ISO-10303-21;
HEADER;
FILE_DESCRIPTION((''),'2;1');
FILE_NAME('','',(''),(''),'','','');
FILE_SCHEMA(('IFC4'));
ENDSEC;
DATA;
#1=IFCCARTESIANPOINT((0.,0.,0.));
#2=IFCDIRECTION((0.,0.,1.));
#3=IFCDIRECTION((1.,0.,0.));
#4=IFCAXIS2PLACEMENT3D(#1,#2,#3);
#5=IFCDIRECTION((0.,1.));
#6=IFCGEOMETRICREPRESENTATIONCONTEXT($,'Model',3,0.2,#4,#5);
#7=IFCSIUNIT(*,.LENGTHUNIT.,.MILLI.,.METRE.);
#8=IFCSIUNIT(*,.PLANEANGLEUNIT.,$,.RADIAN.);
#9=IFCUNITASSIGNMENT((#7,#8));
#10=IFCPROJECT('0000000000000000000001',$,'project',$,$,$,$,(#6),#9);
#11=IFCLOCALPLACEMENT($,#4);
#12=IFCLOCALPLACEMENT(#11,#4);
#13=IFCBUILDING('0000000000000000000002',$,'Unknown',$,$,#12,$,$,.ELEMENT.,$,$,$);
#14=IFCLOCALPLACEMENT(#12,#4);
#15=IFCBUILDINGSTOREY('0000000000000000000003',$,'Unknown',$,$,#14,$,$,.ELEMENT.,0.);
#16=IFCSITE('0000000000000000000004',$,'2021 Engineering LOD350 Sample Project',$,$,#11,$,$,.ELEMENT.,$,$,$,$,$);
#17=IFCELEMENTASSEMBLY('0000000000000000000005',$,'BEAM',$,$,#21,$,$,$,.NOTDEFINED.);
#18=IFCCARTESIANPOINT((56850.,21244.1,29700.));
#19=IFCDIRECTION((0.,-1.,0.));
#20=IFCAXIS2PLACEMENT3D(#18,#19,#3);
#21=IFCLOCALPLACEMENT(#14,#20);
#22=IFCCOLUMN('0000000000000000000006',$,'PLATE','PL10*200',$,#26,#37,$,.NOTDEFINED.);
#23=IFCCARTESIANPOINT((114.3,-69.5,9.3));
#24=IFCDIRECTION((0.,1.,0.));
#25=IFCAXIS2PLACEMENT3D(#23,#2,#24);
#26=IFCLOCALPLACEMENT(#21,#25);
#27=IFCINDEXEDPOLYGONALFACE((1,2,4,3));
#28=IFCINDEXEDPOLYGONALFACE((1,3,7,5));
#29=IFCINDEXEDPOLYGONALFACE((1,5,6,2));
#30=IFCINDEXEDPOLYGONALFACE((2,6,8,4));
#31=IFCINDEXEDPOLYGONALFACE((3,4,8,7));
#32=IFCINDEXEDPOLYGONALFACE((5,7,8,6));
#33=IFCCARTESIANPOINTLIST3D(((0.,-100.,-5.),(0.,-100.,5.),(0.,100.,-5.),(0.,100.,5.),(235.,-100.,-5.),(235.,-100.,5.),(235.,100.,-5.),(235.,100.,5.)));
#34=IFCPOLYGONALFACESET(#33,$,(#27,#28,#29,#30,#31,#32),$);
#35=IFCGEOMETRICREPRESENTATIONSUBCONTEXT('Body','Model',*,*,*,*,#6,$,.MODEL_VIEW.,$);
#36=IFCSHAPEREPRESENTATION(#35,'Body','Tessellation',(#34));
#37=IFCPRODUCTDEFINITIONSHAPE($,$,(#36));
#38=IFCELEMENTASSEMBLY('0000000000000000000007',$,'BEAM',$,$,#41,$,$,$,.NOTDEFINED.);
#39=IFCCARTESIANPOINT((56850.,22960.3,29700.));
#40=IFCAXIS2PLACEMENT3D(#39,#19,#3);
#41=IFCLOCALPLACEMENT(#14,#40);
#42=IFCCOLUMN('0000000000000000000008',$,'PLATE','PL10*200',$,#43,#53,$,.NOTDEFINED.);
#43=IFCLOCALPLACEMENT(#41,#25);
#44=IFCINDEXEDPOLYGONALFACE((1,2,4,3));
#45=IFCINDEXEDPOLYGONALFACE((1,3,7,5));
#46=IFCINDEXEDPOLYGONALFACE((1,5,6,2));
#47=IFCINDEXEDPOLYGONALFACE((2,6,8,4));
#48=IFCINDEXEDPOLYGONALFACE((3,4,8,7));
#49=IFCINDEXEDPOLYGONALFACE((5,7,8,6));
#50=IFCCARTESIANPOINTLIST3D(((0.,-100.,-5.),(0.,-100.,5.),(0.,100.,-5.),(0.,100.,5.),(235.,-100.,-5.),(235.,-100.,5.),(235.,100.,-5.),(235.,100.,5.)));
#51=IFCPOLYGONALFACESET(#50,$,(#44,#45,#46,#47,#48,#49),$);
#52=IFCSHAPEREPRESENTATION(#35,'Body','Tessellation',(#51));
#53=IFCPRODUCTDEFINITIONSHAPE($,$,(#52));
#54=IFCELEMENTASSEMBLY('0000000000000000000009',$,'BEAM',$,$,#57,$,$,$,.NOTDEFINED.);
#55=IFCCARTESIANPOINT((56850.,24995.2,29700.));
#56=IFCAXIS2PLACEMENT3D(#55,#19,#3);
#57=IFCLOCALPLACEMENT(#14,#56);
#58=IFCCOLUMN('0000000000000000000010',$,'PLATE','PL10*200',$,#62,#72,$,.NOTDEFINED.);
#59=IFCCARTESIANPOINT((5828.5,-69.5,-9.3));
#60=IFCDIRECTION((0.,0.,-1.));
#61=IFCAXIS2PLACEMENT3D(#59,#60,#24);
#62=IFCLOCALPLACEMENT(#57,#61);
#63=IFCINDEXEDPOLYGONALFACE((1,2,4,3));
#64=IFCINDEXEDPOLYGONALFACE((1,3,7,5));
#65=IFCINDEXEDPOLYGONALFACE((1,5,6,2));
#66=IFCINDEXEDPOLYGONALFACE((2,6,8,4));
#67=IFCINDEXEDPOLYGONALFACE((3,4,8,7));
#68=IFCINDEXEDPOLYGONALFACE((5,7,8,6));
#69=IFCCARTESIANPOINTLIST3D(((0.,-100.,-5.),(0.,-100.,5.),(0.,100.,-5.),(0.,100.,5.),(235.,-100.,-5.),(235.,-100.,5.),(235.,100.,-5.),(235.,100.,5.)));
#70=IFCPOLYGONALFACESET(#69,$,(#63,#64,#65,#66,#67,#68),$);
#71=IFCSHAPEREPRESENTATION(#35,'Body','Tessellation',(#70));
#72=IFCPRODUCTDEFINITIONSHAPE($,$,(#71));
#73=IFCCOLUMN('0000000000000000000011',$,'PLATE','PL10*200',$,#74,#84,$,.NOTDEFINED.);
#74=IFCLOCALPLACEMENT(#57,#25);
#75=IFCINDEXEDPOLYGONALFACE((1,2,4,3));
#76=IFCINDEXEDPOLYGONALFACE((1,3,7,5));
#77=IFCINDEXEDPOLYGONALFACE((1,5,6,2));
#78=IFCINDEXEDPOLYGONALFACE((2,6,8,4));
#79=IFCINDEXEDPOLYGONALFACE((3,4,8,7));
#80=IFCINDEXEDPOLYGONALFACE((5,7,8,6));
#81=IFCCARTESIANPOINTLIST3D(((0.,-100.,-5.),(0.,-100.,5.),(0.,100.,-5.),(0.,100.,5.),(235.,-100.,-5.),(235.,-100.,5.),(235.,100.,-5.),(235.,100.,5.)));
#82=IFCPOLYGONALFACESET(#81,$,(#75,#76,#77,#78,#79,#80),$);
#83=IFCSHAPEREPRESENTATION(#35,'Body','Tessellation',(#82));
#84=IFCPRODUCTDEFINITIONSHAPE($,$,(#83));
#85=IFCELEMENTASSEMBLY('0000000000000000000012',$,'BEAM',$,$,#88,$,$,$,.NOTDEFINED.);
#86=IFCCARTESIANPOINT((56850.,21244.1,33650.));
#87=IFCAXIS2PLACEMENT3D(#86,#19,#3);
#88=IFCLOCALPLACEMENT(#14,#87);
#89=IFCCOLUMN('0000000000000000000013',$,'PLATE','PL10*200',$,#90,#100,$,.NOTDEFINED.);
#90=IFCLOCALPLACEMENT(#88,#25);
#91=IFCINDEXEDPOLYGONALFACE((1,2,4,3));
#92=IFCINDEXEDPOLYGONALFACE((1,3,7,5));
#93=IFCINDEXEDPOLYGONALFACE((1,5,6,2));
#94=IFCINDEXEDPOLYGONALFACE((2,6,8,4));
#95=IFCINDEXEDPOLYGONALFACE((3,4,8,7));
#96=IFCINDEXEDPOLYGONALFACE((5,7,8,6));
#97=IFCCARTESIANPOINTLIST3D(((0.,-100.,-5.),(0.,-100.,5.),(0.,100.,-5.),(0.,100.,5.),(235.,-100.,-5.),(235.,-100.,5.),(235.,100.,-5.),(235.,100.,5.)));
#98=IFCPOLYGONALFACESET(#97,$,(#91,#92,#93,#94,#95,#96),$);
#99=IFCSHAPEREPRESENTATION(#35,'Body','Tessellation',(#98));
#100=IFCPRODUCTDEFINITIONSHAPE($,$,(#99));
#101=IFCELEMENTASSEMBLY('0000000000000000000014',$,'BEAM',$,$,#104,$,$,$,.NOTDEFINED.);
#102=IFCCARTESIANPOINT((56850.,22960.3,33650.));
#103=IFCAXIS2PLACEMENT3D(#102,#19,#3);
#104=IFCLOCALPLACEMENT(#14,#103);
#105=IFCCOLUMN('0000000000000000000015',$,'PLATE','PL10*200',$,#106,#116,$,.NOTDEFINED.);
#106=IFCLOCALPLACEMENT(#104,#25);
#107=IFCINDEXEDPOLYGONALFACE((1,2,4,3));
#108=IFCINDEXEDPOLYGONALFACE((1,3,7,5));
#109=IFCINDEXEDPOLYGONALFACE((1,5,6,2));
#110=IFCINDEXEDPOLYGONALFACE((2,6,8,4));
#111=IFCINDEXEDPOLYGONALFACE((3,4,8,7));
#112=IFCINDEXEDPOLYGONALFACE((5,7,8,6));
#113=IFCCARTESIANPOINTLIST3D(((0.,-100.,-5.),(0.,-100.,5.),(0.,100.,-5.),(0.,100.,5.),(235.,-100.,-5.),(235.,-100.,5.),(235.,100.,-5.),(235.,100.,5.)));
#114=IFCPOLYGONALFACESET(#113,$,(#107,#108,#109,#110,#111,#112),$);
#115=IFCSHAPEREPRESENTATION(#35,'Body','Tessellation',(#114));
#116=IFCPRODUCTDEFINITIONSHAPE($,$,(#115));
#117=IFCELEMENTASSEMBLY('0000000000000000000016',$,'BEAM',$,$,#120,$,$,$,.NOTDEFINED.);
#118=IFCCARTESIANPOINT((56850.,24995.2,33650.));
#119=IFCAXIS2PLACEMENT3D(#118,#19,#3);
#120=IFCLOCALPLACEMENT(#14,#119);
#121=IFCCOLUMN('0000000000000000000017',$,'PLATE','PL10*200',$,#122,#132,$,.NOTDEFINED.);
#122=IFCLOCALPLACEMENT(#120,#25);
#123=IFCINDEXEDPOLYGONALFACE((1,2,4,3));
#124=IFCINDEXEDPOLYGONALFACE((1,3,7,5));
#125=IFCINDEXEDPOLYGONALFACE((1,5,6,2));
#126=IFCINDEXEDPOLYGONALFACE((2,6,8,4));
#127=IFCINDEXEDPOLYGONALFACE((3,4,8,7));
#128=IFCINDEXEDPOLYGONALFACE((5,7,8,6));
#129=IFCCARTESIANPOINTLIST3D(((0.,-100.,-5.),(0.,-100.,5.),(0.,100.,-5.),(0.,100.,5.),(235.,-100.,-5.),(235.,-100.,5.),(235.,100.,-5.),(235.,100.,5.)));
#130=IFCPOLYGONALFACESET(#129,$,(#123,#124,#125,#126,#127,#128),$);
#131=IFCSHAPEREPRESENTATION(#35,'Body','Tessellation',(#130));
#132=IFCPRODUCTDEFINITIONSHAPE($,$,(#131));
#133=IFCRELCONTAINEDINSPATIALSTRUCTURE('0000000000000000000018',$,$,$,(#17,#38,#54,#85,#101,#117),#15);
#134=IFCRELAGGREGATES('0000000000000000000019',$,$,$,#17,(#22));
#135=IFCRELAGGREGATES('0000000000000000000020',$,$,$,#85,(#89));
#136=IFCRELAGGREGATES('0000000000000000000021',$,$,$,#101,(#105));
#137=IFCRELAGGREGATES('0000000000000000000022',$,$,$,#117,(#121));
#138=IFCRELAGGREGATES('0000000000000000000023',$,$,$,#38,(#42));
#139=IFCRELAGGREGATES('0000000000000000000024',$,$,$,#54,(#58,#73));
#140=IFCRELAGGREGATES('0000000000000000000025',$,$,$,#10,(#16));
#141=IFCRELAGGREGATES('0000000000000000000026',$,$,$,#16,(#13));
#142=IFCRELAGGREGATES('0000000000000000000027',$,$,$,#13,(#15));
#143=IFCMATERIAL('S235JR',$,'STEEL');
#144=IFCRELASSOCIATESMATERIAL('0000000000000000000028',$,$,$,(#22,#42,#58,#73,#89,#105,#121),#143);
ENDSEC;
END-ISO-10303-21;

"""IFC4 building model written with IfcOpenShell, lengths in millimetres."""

from ifc_helpers import new_model, si_unit, direction, frame, origin_with_axes, place, context, subcontext, project, spatial, line, indexed_curve, outline, extrude, material, element, aggregate, save


model = new_model("IFC4")

# Units and contexts
model_context = context("Model", 3, precision=0.2, world=origin_with_axes(), true_north=direction((0.0, 1.0)))
body_context = subcontext(model_context, "Body", "Model", "MODEL_VIEW")
ifc_project = project(units=[si_unit("LENGTHUNIT", "METRE", prefix="MILLI"), si_unit("PLANEANGLEUNIT", "RADIAN")], contexts=[model_context])

# Site, building, storey
site_placement = place(None, origin_with_axes())
site = spatial("IfcSite", under=ifc_project, at=site_placement, Name="2021 Engineering LOD350 Sample Project", CompositionType="ELEMENT")
building_placement = place(site_placement, origin_with_axes())
building = spatial("IfcBuilding", under=site, at=building_placement, Name="Unknown", CompositionType="ELEMENT")
storey_placement = place(building_placement, origin_with_axes())
storey = spatial("IfcBuildingStorey", under=building, at=storey_placement, Name="Unknown", CompositionType="ELEMENT", Elevation=0.0)

# Shared definitions
ifc_material_1 = material(Name="S235JR", Category="STEEL")

# Element assembly, column
assembly_1_placement = place(storey_placement, frame((56850.0, 21244.1, 29700.0), z_axis=(0.0, -1.0, 0.0), x_axis=(1.0, 0.0, 0.0)))
assembly_1 = element("IfcElementAssembly", 1, at=assembly_1_placement, inside=storey, Name="BEAM", PredefinedType="NOTDEFINED")
column_1_placement = place(assembly_1_placement, frame((114.3, -69.5, 9.3), z_axis=(0.0, 0.0, 1.0), x_axis=(0.0, 1.0, 0.0)))
column_1 = element("IfcColumn", 2, at=column_1_placement, material=ifc_material_1, Name="PLATE", Description="PL10*200", PredefinedType="NOTDEFINED", context=body_context, shape_type="SolidModel", body=[
    extrude(outline(indexed_curve([(-5.0, -100.0), (5.0, -100.0), (5.0, 100.0), (-5.0, 100.0)], segments=[line(1, 2, 3, 4, 1)])), frame((0.0, 0.0, 0.0), z_axis=(-1.0, 0.0, 0.0), x_axis=(0.0, 0.0, 1.0)), (0.0, 0.0, -1.0), 235.0),
])
aggregate(assembly_1, [column_1])

# Element assemblies, columns
assembly_2_placement = place(storey_placement, frame((56850.0, 22960.3, 29700.0), z_axis=(0.0, -1.0, 0.0), x_axis=(1.0, 0.0, 0.0)))
assembly_2 = element("IfcElementAssembly", 3, at=assembly_2_placement, inside=storey, Name="BEAM", PredefinedType="NOTDEFINED")
column_2_placement = place(assembly_2_placement, frame((114.3, -69.5, 9.3), z_axis=(0.0, 0.0, 1.0), x_axis=(0.0, 1.0, 0.0)))
column_2 = element("IfcColumn", 4, at=column_2_placement, material=ifc_material_1, Name="PLATE", Description="PL10*200", PredefinedType="NOTDEFINED", context=body_context, shape_type="SolidModel", body=[
    extrude(outline(indexed_curve([(-5.0, -100.0), (5.0, -100.0), (5.0, 100.0), (-5.0, 100.0)], segments=[line(1, 2, 3, 4, 1)])), frame((0.0, 0.0, 0.0), z_axis=(-1.0, 0.0, 0.0), x_axis=(0.0, 0.0, 1.0)), (0.0, 0.0, -1.0), 235.0),
])
assembly_3_placement = place(storey_placement, frame((56850.0, 24995.2, 29700.0), z_axis=(0.0, -1.0, 0.0), x_axis=(1.0, 0.0, 0.0)))
assembly_3 = element("IfcElementAssembly", 5, at=assembly_3_placement, inside=storey, Name="BEAM", PredefinedType="NOTDEFINED")
column_3_placement = place(assembly_3_placement, frame((5828.5, -69.5, -9.3), z_axis=(0.0, 0.0, -1.0), x_axis=(0.0, 1.0, 0.0)))
column_3 = element("IfcColumn", 6, at=column_3_placement, material=ifc_material_1, Name="PLATE", Description="PL10*200", PredefinedType="NOTDEFINED", context=body_context, shape_type="SolidModel", body=[
    extrude(outline(indexed_curve([(-5.0, -100.0), (5.0, -100.0), (5.0, 100.0), (-5.0, 100.0)], segments=[line(1, 2, 3, 4, 1)])), frame((0.0, 0.0, 0.0), z_axis=(-1.0, 0.0, 0.0), x_axis=(0.0, 0.0, 1.0)), (0.0, 0.0, -1.0), 235.0),
])
column_4_placement = place(assembly_3_placement, frame((114.3, -69.5, 9.3), z_axis=(0.0, 0.0, 1.0), x_axis=(0.0, 1.0, 0.0)))
column_4 = element("IfcColumn", 7, at=column_4_placement, material=ifc_material_1, Name="PLATE", Description="PL10*200", PredefinedType="NOTDEFINED", context=body_context, shape_type="SolidModel", body=[
    extrude(outline(indexed_curve([(-5.0, -100.0), (5.0, -100.0), (5.0, 100.0), (-5.0, 100.0)], segments=[line(1, 2, 3, 4, 1)])), frame((0.0, 0.0, 0.0), z_axis=(-1.0, 0.0, 0.0), x_axis=(0.0, 0.0, 1.0)), (0.0, 0.0, -1.0), 235.0),
])

# Element assemblies, columns
assembly_4_placement = place(storey_placement, frame((56850.0, 21244.1, 33650.0), z_axis=(0.0, -1.0, 0.0), x_axis=(1.0, 0.0, 0.0)))
assembly_4 = element("IfcElementAssembly", 8, at=assembly_4_placement, inside=storey, Name="BEAM", PredefinedType="NOTDEFINED")
column_5_placement = place(assembly_4_placement, frame((114.3, -69.5, 9.3), z_axis=(0.0, 0.0, 1.0), x_axis=(0.0, 1.0, 0.0)))
column_5 = element("IfcColumn", 9, at=column_5_placement, material=ifc_material_1, Name="PLATE", Description="PL10*200", PredefinedType="NOTDEFINED", context=body_context, shape_type="SolidModel", body=[
    extrude(outline(indexed_curve([(-5.0, -100.0), (5.0, -100.0), (5.0, 100.0), (-5.0, 100.0)], segments=[line(1, 2, 3, 4, 1)])), frame((0.0, 0.0, 0.0), z_axis=(-1.0, 0.0, 0.0), x_axis=(0.0, 0.0, 1.0)), (0.0, 0.0, -1.0), 235.0),
])
aggregate(assembly_4, [column_5])
assembly_5_placement = place(storey_placement, frame((56850.0, 22960.3, 33650.0), z_axis=(0.0, -1.0, 0.0), x_axis=(1.0, 0.0, 0.0)))
assembly_5 = element("IfcElementAssembly", 10, at=assembly_5_placement, inside=storey, Name="BEAM", PredefinedType="NOTDEFINED")
column_6_placement = place(assembly_5_placement, frame((114.3, -69.5, 9.3), z_axis=(0.0, 0.0, 1.0), x_axis=(0.0, 1.0, 0.0)))
column_6 = element("IfcColumn", 11, at=column_6_placement, material=ifc_material_1, Name="PLATE", Description="PL10*200", PredefinedType="NOTDEFINED", context=body_context, shape_type="SolidModel", body=[
    extrude(outline(indexed_curve([(-5.0, -100.0), (5.0, -100.0), (5.0, 100.0), (-5.0, 100.0)], segments=[line(1, 2, 3, 4, 1)])), frame((0.0, 0.0, 0.0), z_axis=(-1.0, 0.0, 0.0), x_axis=(0.0, 0.0, 1.0)), (0.0, 0.0, -1.0), 235.0),
])
aggregate(assembly_5, [column_6])
assembly_6_placement = place(storey_placement, frame((56850.0, 24995.2, 33650.0), z_axis=(0.0, -1.0, 0.0), x_axis=(1.0, 0.0, 0.0)))
assembly_6 = element("IfcElementAssembly", 12, at=assembly_6_placement, inside=storey, Name="BEAM", PredefinedType="NOTDEFINED")
column_7_placement = place(assembly_6_placement, frame((114.3, -69.5, 9.3), z_axis=(0.0, 0.0, 1.0), x_axis=(0.0, 1.0, 0.0)))
column_7 = element("IfcColumn", 13, at=column_7_placement, material=ifc_material_1, Name="PLATE", Description="PL10*200", PredefinedType="NOTDEFINED", context=body_context, shape_type="SolidModel", body=[
    extrude(outline(indexed_curve([(-5.0, -100.0), (5.0, -100.0), (5.0, 100.0), (-5.0, 100.0)], segments=[line(1, 2, 3, 4, 1)])), frame((0.0, 0.0, 0.0), z_axis=(-1.0, 0.0, 0.0), x_axis=(0.0, 0.0, 1.0)), (0.0, 0.0, -1.0), 235.0),
])
aggregate(assembly_6, [column_7])

aggregate(assembly_2, [column_2])
aggregate(assembly_3, [column_3, column_4])

save(model, "model.ifc")
